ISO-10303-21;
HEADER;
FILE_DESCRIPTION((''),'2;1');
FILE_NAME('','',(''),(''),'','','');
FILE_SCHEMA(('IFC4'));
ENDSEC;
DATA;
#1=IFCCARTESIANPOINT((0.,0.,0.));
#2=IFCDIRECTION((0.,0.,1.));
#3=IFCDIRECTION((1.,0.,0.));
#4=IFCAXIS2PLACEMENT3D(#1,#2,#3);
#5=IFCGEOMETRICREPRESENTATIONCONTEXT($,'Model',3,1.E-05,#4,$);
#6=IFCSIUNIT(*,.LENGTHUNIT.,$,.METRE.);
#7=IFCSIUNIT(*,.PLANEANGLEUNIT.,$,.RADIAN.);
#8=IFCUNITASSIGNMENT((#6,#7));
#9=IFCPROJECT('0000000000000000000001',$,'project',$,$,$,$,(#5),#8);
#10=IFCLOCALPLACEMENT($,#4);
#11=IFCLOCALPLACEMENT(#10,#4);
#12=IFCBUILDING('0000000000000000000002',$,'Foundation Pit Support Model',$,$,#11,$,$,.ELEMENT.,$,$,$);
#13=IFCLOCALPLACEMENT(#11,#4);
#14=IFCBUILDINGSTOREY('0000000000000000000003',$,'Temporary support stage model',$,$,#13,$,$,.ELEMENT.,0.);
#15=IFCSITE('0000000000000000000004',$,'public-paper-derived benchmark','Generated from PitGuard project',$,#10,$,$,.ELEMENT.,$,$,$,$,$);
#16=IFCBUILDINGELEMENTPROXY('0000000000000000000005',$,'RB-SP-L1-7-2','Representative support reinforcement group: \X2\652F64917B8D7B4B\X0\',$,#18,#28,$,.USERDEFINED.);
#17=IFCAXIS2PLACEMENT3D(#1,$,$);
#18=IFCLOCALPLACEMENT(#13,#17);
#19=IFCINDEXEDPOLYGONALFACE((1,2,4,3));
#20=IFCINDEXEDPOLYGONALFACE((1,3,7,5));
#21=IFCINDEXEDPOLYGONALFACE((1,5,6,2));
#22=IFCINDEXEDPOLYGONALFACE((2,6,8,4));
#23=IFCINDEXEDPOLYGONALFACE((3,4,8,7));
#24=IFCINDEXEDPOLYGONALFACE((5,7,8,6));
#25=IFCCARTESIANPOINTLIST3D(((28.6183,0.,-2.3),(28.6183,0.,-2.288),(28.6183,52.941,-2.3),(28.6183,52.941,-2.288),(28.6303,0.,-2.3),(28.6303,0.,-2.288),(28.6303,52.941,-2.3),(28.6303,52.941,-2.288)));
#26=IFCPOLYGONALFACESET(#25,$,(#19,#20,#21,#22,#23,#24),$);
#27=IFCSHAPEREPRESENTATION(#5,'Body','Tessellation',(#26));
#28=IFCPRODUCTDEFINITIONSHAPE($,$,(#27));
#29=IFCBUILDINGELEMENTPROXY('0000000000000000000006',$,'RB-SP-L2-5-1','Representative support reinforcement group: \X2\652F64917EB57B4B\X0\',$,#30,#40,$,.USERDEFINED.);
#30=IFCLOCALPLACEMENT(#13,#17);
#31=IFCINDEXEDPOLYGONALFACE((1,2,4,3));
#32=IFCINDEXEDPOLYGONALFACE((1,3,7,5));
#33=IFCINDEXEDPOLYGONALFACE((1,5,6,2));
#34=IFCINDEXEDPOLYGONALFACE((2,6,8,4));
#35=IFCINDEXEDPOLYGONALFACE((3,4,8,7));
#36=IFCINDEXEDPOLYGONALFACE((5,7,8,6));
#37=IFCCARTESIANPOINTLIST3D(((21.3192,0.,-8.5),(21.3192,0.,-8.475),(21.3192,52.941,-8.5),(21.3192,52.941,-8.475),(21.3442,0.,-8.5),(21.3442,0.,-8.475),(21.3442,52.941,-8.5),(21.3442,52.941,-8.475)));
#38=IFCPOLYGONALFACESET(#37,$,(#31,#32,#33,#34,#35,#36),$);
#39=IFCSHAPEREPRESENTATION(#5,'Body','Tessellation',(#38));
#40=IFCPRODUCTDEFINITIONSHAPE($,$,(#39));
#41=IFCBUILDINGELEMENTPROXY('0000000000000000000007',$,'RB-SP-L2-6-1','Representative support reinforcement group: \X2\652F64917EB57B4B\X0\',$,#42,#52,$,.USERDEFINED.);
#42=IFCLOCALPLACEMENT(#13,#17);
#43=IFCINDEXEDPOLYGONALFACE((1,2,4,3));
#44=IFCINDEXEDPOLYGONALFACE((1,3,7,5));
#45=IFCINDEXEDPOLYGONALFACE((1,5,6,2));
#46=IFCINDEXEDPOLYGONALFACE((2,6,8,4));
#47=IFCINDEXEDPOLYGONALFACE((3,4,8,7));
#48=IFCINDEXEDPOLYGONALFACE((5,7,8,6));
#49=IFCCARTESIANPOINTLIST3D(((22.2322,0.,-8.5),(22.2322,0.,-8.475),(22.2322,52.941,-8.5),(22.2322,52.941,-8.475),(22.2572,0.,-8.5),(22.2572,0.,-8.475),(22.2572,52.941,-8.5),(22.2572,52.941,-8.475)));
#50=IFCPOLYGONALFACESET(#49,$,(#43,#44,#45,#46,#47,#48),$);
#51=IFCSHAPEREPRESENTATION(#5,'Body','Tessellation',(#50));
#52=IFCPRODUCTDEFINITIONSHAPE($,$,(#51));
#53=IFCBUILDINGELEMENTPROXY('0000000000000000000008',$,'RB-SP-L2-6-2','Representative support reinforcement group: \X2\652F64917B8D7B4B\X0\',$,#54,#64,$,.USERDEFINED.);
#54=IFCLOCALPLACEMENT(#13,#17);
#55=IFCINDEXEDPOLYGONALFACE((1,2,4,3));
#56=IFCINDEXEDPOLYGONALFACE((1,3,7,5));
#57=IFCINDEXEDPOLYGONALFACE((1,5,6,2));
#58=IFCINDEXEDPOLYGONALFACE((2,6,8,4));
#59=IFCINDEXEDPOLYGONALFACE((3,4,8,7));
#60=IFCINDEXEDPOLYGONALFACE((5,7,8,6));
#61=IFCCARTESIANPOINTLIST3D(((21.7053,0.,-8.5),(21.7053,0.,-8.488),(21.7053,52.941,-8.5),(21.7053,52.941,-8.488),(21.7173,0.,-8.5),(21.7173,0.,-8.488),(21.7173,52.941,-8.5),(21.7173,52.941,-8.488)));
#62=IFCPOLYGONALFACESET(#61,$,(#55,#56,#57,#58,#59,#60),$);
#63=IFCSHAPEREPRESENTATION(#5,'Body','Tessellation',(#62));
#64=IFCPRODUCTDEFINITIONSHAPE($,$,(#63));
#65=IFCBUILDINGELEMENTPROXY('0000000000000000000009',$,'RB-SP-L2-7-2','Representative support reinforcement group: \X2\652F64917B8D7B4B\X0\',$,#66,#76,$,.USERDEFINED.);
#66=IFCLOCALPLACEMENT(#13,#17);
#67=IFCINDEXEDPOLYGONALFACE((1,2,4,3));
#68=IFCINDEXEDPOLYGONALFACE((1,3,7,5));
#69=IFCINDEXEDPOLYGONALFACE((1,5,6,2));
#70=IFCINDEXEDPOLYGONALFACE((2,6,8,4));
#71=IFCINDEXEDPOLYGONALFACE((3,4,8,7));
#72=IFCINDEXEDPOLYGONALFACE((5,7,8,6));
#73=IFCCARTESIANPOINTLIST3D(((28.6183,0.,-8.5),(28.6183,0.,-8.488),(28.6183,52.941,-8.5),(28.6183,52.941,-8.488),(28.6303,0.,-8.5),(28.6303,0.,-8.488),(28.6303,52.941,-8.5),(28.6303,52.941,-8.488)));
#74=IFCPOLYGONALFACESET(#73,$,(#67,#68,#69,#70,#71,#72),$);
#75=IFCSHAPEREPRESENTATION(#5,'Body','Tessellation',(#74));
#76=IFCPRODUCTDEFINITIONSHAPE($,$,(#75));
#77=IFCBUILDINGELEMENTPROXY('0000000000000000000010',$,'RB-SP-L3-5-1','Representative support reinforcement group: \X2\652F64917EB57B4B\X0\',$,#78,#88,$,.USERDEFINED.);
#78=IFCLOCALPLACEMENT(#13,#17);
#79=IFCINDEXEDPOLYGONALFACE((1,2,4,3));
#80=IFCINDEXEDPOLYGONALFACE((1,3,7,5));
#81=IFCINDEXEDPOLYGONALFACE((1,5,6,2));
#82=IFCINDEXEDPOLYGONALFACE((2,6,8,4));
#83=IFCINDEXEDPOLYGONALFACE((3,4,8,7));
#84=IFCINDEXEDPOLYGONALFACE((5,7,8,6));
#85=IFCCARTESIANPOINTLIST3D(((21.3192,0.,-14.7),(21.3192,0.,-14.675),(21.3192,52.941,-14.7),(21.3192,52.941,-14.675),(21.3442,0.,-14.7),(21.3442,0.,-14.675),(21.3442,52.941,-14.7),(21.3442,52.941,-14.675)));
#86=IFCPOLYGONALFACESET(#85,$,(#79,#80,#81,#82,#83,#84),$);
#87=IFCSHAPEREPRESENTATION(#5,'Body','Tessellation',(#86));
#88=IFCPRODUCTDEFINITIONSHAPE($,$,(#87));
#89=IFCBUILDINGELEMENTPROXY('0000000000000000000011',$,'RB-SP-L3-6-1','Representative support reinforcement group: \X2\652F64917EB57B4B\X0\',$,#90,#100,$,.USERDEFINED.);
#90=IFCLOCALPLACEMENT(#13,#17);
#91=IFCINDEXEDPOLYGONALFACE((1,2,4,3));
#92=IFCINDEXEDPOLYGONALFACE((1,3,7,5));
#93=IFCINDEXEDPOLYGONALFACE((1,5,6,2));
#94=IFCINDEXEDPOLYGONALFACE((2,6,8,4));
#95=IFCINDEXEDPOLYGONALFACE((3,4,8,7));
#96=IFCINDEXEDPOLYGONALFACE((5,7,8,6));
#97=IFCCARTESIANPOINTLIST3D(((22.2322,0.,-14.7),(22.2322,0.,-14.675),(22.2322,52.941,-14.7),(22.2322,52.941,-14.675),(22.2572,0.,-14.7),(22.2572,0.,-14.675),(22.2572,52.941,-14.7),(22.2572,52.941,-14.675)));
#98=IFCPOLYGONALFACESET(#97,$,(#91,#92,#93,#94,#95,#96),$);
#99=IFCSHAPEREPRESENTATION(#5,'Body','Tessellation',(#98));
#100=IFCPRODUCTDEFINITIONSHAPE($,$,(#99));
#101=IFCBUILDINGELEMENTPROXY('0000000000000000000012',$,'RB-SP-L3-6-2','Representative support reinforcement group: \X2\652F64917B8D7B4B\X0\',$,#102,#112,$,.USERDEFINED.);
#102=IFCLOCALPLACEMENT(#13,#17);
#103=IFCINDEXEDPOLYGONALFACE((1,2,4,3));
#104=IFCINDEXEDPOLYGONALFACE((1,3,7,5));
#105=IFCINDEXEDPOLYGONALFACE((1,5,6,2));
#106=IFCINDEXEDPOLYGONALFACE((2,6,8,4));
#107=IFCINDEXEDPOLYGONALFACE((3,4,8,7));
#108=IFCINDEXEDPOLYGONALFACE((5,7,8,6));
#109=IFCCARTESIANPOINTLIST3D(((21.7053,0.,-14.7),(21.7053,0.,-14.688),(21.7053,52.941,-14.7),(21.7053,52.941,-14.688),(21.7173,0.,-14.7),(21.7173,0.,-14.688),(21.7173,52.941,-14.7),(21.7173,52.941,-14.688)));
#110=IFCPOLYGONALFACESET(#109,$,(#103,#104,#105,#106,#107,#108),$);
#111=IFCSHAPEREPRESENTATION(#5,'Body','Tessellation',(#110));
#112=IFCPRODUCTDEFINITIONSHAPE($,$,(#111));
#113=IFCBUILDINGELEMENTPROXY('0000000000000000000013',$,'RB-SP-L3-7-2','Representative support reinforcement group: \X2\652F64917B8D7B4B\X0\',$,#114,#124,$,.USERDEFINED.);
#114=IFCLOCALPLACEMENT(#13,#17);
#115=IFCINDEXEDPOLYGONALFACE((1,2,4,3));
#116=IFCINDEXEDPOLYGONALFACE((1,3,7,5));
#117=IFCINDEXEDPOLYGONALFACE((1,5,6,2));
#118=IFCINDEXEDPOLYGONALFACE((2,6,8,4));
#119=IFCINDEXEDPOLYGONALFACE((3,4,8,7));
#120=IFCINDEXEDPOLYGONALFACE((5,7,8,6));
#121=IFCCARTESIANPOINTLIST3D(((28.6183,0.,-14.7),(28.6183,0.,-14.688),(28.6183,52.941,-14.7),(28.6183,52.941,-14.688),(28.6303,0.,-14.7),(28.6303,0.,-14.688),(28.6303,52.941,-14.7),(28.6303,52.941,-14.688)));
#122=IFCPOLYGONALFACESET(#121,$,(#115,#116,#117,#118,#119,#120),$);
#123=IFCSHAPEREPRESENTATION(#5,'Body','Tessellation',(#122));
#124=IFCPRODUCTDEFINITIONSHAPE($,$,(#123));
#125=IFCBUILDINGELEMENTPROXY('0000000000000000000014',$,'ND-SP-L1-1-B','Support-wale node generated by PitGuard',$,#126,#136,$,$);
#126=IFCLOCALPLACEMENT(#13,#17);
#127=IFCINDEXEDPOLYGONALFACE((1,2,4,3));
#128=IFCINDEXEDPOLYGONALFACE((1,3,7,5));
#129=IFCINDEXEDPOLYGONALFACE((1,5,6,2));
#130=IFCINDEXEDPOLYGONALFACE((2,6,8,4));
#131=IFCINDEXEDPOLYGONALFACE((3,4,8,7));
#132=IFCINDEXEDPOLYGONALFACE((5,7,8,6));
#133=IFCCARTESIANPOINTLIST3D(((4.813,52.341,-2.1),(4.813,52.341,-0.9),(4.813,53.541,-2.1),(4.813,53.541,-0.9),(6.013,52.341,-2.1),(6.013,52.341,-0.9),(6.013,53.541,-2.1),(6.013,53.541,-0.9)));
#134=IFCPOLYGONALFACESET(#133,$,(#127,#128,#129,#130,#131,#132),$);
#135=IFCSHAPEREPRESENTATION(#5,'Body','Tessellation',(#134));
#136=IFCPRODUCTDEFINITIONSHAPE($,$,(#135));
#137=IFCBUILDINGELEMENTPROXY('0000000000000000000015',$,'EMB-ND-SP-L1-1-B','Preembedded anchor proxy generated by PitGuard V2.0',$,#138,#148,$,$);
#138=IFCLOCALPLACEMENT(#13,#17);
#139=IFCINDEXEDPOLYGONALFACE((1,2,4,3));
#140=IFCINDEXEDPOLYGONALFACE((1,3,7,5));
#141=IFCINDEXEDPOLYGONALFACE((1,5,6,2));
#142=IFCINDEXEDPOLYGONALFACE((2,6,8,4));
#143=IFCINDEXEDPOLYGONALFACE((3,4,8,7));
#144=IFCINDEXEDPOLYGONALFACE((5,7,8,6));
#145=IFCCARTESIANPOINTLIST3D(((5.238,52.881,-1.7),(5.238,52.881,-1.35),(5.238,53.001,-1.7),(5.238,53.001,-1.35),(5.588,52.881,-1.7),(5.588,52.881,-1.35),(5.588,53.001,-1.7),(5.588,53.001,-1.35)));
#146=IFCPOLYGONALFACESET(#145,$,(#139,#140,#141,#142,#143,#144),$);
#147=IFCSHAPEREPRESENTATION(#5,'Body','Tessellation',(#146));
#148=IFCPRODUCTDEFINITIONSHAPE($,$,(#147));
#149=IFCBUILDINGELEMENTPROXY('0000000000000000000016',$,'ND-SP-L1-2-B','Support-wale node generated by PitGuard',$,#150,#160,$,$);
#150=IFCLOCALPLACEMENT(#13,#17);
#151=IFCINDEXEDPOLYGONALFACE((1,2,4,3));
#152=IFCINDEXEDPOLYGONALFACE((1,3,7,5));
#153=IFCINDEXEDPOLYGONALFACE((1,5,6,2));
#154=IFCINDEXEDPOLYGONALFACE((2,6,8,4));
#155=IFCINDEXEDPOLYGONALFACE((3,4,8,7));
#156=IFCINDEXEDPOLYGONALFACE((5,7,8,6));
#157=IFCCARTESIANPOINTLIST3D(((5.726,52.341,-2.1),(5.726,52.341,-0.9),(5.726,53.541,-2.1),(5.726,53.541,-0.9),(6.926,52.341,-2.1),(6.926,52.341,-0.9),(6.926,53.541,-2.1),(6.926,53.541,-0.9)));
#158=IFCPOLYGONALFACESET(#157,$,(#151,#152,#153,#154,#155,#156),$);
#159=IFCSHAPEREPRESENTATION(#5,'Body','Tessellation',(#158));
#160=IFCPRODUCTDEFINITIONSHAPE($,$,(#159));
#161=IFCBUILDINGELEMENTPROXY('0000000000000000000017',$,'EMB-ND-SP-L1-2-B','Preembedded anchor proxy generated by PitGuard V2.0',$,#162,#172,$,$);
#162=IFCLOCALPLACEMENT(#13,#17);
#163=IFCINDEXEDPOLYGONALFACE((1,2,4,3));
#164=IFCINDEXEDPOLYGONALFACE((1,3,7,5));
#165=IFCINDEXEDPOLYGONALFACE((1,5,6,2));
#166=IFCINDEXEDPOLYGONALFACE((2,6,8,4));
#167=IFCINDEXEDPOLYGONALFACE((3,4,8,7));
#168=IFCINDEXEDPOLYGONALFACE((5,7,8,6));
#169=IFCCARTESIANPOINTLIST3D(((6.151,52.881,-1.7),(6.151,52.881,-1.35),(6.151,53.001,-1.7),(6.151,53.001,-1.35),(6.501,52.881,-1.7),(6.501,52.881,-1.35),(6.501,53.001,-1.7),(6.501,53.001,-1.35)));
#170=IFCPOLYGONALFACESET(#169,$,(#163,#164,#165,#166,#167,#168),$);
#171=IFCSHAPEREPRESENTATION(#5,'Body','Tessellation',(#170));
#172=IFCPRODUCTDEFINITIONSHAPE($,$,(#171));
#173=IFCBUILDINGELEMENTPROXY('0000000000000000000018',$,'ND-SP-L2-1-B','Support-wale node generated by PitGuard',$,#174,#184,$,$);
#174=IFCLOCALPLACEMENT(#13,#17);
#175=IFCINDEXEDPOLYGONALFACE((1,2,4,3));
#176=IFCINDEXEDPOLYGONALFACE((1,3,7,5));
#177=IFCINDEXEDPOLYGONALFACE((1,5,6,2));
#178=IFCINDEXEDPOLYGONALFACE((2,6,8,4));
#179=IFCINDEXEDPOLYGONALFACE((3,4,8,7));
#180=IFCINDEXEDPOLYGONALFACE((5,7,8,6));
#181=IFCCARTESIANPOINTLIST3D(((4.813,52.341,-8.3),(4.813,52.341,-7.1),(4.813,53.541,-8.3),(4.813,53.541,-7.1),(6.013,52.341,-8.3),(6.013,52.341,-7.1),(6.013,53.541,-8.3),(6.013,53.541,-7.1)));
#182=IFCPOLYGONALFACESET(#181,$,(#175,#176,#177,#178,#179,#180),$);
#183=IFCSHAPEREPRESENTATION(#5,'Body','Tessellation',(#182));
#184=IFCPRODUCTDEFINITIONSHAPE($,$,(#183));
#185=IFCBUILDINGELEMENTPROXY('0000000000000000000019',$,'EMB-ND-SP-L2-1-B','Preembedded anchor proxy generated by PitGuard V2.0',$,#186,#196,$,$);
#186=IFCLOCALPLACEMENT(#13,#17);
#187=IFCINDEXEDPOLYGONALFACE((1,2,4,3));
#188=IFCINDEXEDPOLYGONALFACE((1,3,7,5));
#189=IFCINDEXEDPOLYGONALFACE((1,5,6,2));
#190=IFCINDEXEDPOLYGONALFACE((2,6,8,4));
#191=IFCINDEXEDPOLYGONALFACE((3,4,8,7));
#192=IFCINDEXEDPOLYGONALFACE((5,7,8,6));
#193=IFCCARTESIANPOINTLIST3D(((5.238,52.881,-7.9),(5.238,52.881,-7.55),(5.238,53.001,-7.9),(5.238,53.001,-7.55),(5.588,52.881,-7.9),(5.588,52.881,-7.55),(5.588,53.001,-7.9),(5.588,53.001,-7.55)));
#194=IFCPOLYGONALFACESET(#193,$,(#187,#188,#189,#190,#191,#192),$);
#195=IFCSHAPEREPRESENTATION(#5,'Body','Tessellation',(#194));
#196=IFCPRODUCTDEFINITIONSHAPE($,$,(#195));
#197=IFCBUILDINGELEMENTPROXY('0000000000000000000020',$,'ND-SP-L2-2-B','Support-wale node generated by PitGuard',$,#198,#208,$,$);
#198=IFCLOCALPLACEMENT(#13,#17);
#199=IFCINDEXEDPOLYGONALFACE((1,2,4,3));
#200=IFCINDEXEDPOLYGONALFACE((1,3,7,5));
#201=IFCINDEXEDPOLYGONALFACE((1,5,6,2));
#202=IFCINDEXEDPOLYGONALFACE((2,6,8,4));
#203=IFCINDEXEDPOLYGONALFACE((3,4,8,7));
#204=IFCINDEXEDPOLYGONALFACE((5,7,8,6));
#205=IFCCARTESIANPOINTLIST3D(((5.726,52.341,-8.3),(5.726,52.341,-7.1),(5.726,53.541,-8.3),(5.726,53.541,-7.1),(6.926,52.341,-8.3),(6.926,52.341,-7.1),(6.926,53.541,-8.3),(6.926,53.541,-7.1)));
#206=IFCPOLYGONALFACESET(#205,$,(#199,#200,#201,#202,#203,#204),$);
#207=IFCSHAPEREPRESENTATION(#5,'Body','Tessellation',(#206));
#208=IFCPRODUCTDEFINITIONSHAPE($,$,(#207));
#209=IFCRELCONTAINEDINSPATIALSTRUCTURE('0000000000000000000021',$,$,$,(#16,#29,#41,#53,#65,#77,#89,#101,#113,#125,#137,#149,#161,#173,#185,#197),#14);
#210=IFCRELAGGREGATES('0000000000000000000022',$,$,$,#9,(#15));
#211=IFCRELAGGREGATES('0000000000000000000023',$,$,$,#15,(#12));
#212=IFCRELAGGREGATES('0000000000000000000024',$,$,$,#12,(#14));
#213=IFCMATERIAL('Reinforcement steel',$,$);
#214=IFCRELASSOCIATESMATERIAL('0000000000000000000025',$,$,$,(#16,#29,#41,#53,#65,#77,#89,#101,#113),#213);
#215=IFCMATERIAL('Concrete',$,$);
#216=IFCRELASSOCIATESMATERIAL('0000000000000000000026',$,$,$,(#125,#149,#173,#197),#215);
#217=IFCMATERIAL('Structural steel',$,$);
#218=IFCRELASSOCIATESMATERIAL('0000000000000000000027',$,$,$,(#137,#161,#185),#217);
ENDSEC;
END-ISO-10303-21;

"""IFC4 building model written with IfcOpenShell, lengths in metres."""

from ifc_helpers import new_model, si_unit, frame, origin_with_axes, origin_2d, place, context, project, spatial, rectangle, extrude, material, element, save


model = new_model("IFC4")

# Units and contexts
model_context = context("Model", 3, precision=1e-05, world=origin_with_axes())
ifc_project = project(units=[si_unit("LENGTHUNIT", "METRE"), si_unit("PLANEANGLEUNIT", "RADIAN")], contexts=[model_context])

# Site, building, storey
site_placement = place(None, origin_with_axes())
site = spatial("IfcSite", under=ifc_project, at=site_placement, Name="public-paper-derived benchmark", Description="Generated from PitGuard project", CompositionType="ELEMENT")
building_placement = place(site_placement, origin_with_axes())
building = spatial("IfcBuilding", under=site, at=building_placement, Name="Foundation Pit Support Model", CompositionType="ELEMENT")
storey_placement = place(building_placement, origin_with_axes())
storey = spatial("IfcBuildingStorey", under=building, at=storey_placement, Name="Temporary support stage model", CompositionType="ELEMENT", Elevation=0.0)

# Shared definitions
ifc_material_1 = material(Name="Structural steel")

# Shared definitions
ifc_material_2 = material(Name="Concrete")

# Building element proxies
ifc_material_3 = material(Name="Reinforcement steel")
for number, where, z_axis, x_axis, name in (
    (1, (28.6243, 26.4705, -2.3), (0.0, 0.0, 1.0), (0.0, 1.0, 0.0), "RB-SP-L1-7-2"),
):
    element("IfcBuildingElementProxy", number, at=place(storey_placement, frame(where, z_axis=z_axis, x_axis=x_axis)), inside=storey, material=ifc_material_3, Name=name, Description="Representative support reinforcement group: 支撑箍筋", PredefinedType="USERDEFINED", context=model_context, shape_type="SweptSolid", body=[
        extrude(rectangle(XDim=52.941, YDim=0.012, at=origin_2d()), origin_with_axes(), (0.0, 0.0, 1.0), 0.012),
    ])
for number, where, z_axis, x_axis, name in (
    (2, (21.3317, 26.4705, -8.5), (0.0, 0.0, 1.0), (0.0, 1.0, 0.0), "RB-SP-L2-5-1"),
    (3, (22.2447, 26.4705, -8.5), (0.0, 0.0, 1.0), (0.0, 1.0, 0.0), "RB-SP-L2-6-1"),
):
    element("IfcBuildingElementProxy", number, at=place(storey_placement, frame(where, z_axis=z_axis, x_axis=x_axis)), inside=storey, material=ifc_material_3, Name=name, Description="Representative support reinforcement group: 支撑纵筋", PredefinedType="USERDEFINED", context=model_context, shape_type="SweptSolid", body=[
        extrude(rectangle(XDim=52.941, YDim=0.025, at=origin_2d()), origin_with_axes(), (0.0, 0.0, 1.0), 0.025),
    ])
for number, where, z_axis, x_axis, name in (
    (4, (21.7113, 26.4705, -8.5), (0.0, 0.0, 1.0), (0.0, 1.0, 0.0), "RB-SP-L2-6-2"),
    (5, (28.6243, 26.4705, -8.5), (0.0, 0.0, 1.0), (0.0, 1.0, 0.0), "RB-SP-L2-7-2"),
):
    element("IfcBuildingElementProxy", number, at=place(storey_placement, frame(where, z_axis=z_axis, x_axis=x_axis)), inside=storey, material=ifc_material_3, Name=name, Description="Representative support reinforcement group: 支撑箍筋", PredefinedType="USERDEFINED", context=model_context, shape_type="SweptSolid", body=[
        extrude(rectangle(XDim=52.941, YDim=0.012, at=origin_2d()), origin_with_axes(), (0.0, 0.0, 1.0), 0.012),
    ])
for number, where, z_axis, x_axis, name in (
    (6, (21.3317, 26.4705, -14.7), (0.0, 0.0, 1.0), (0.0, 1.0, 0.0), "RB-SP-L3-5-1"),
    (7, (22.2447, 26.4705, -14.7), (0.0, 0.0, 1.0), (0.0, 1.0, 0.0), "RB-SP-L3-6-1"),
):
    element("IfcBuildingElementProxy", number, at=place(storey_placement, frame(where, z_axis=z_axis, x_axis=x_axis)), inside=storey, material=ifc_material_3, Name=name, Description="Representative support reinforcement group: 支撑纵筋", PredefinedType="USERDEFINED", context=model_context, shape_type="SweptSolid", body=[
        extrude(rectangle(XDim=52.941, YDim=0.025, at=origin_2d()), origin_with_axes(), (0.0, 0.0, 1.0), 0.025),
    ])
for number, where, z_axis, x_axis, name in (
    (8, (21.7113, 26.4705, -14.7), (0.0, 0.0, 1.0), (0.0, 1.0, 0.0), "RB-SP-L3-6-2"),
    (9, (28.6243, 26.4705, -14.7), (0.0, 0.0, 1.0), (0.0, 1.0, 0.0), "RB-SP-L3-7-2"),
):
    element("IfcBuildingElementProxy", number, at=place(storey_placement, frame(where, z_axis=z_axis, x_axis=x_axis)), inside=storey, material=ifc_material_3, Name=name, Description="Representative support reinforcement group: 支撑箍筋", PredefinedType="USERDEFINED", context=model_context, shape_type="SweptSolid", body=[
        extrude(rectangle(XDim=52.941, YDim=0.012, at=origin_2d()), origin_with_axes(), (0.0, 0.0, 1.0), 0.012),
    ])
proxy_1_placement = place(storey_placement, frame((5.413, 52.941, -2.1), z_axis=(0.0, 0.0, 1.0), x_axis=(1.0, 0.0, 0.0)))
element("IfcBuildingElementProxy", 10, at=proxy_1_placement, inside=storey, material=ifc_material_2, Name="ND-SP-L1-1-B", Description="Support-wale node generated by PitGuard", context=model_context, shape_type="SweptSolid", body=[
    extrude(rectangle(XDim=1.2, YDim=1.2, at=origin_2d()), origin_with_axes(), (0.0, 0.0, 1.0), 1.2),
])
proxy_2_placement = place(storey_placement, frame((5.413, 52.941, -1.7), z_axis=(0.0, 0.0, 1.0), x_axis=(1.0, 0.0, 0.0)))
element("IfcBuildingElementProxy", 11, at=proxy_2_placement, inside=storey, material=ifc_material_1, Name="EMB-ND-SP-L1-1-B", Description="Preembedded anchor proxy generated by PitGuard V2.0", context=model_context, shape_type="SweptSolid", body=[
    extrude(rectangle(XDim=0.35, YDim=0.12, at=origin_2d()), origin_with_axes(), (0.0, 0.0, 1.0), 0.35),
])
proxy_3_placement = place(storey_placement, frame((6.326, 52.941, -2.1), z_axis=(0.0, 0.0, 1.0), x_axis=(1.0, 0.0, 0.0)))
element("IfcBuildingElementProxy", 12, at=proxy_3_placement, inside=storey, material=ifc_material_2, Name="ND-SP-L1-2-B", Description="Support-wale node generated by PitGuard", context=model_context, shape_type="SweptSolid", body=[
    extrude(rectangle(XDim=1.2, YDim=1.2, at=origin_2d()), origin_with_axes(), (0.0, 0.0, 1.0), 1.2),
])
proxy_4_placement = place(storey_placement, frame((6.326, 52.941, -1.7), z_axis=(0.0, 0.0, 1.0), x_axis=(1.0, 0.0, 0.0)))
element("IfcBuildingElementProxy", 13, at=proxy_4_placement, inside=storey, material=ifc_material_1, Name="EMB-ND-SP-L1-2-B", Description="Preembedded anchor proxy generated by PitGuard V2.0", context=model_context, shape_type="SweptSolid", body=[
    extrude(rectangle(XDim=0.35, YDim=0.12, at=origin_2d()), origin_with_axes(), (0.0, 0.0, 1.0), 0.35),
])
proxy_5_placement = place(storey_placement, frame((5.413, 52.941, -8.3), z_axis=(0.0, 0.0, 1.0), x_axis=(1.0, 0.0, 0.0)))
element("IfcBuildingElementProxy", 14, at=proxy_5_placement, inside=storey, material=ifc_material_2, Name="ND-SP-L2-1-B", Description="Support-wale node generated by PitGuard", context=model_context, shape_type="SweptSolid", body=[
    extrude(rectangle(XDim=1.2, YDim=1.2, at=origin_2d()), origin_with_axes(), (0.0, 0.0, 1.0), 1.2),
])
proxy_6_placement = place(storey_placement, frame((5.413, 52.941, -7.9), z_axis=(0.0, 0.0, 1.0), x_axis=(1.0, 0.0, 0.0)))
element("IfcBuildingElementProxy", 15, at=proxy_6_placement, inside=storey, material=ifc_material_1, Name="EMB-ND-SP-L2-1-B", Description="Preembedded anchor proxy generated by PitGuard V2.0", context=model_context, shape_type="SweptSolid", body=[
    extrude(rectangle(XDim=0.35, YDim=0.12, at=origin_2d()), origin_with_axes(), (0.0, 0.0, 1.0), 0.35),
])
proxy_7_placement = place(storey_placement, frame((6.326, 52.941, -8.3), z_axis=(0.0, 0.0, 1.0), x_axis=(1.0, 0.0, 0.0)))
element("IfcBuildingElementProxy", 16, at=proxy_7_placement, inside=storey, material=ifc_material_2, Name="ND-SP-L2-2-B", Description="Support-wale node generated by PitGuard", context=model_context, shape_type="SweptSolid", body=[
    extrude(rectangle(XDim=1.2, YDim=1.2, at=origin_2d()), origin_with_axes(), (0.0, 0.0, 1.0), 1.2),
])

save(model, "model.ifc")
